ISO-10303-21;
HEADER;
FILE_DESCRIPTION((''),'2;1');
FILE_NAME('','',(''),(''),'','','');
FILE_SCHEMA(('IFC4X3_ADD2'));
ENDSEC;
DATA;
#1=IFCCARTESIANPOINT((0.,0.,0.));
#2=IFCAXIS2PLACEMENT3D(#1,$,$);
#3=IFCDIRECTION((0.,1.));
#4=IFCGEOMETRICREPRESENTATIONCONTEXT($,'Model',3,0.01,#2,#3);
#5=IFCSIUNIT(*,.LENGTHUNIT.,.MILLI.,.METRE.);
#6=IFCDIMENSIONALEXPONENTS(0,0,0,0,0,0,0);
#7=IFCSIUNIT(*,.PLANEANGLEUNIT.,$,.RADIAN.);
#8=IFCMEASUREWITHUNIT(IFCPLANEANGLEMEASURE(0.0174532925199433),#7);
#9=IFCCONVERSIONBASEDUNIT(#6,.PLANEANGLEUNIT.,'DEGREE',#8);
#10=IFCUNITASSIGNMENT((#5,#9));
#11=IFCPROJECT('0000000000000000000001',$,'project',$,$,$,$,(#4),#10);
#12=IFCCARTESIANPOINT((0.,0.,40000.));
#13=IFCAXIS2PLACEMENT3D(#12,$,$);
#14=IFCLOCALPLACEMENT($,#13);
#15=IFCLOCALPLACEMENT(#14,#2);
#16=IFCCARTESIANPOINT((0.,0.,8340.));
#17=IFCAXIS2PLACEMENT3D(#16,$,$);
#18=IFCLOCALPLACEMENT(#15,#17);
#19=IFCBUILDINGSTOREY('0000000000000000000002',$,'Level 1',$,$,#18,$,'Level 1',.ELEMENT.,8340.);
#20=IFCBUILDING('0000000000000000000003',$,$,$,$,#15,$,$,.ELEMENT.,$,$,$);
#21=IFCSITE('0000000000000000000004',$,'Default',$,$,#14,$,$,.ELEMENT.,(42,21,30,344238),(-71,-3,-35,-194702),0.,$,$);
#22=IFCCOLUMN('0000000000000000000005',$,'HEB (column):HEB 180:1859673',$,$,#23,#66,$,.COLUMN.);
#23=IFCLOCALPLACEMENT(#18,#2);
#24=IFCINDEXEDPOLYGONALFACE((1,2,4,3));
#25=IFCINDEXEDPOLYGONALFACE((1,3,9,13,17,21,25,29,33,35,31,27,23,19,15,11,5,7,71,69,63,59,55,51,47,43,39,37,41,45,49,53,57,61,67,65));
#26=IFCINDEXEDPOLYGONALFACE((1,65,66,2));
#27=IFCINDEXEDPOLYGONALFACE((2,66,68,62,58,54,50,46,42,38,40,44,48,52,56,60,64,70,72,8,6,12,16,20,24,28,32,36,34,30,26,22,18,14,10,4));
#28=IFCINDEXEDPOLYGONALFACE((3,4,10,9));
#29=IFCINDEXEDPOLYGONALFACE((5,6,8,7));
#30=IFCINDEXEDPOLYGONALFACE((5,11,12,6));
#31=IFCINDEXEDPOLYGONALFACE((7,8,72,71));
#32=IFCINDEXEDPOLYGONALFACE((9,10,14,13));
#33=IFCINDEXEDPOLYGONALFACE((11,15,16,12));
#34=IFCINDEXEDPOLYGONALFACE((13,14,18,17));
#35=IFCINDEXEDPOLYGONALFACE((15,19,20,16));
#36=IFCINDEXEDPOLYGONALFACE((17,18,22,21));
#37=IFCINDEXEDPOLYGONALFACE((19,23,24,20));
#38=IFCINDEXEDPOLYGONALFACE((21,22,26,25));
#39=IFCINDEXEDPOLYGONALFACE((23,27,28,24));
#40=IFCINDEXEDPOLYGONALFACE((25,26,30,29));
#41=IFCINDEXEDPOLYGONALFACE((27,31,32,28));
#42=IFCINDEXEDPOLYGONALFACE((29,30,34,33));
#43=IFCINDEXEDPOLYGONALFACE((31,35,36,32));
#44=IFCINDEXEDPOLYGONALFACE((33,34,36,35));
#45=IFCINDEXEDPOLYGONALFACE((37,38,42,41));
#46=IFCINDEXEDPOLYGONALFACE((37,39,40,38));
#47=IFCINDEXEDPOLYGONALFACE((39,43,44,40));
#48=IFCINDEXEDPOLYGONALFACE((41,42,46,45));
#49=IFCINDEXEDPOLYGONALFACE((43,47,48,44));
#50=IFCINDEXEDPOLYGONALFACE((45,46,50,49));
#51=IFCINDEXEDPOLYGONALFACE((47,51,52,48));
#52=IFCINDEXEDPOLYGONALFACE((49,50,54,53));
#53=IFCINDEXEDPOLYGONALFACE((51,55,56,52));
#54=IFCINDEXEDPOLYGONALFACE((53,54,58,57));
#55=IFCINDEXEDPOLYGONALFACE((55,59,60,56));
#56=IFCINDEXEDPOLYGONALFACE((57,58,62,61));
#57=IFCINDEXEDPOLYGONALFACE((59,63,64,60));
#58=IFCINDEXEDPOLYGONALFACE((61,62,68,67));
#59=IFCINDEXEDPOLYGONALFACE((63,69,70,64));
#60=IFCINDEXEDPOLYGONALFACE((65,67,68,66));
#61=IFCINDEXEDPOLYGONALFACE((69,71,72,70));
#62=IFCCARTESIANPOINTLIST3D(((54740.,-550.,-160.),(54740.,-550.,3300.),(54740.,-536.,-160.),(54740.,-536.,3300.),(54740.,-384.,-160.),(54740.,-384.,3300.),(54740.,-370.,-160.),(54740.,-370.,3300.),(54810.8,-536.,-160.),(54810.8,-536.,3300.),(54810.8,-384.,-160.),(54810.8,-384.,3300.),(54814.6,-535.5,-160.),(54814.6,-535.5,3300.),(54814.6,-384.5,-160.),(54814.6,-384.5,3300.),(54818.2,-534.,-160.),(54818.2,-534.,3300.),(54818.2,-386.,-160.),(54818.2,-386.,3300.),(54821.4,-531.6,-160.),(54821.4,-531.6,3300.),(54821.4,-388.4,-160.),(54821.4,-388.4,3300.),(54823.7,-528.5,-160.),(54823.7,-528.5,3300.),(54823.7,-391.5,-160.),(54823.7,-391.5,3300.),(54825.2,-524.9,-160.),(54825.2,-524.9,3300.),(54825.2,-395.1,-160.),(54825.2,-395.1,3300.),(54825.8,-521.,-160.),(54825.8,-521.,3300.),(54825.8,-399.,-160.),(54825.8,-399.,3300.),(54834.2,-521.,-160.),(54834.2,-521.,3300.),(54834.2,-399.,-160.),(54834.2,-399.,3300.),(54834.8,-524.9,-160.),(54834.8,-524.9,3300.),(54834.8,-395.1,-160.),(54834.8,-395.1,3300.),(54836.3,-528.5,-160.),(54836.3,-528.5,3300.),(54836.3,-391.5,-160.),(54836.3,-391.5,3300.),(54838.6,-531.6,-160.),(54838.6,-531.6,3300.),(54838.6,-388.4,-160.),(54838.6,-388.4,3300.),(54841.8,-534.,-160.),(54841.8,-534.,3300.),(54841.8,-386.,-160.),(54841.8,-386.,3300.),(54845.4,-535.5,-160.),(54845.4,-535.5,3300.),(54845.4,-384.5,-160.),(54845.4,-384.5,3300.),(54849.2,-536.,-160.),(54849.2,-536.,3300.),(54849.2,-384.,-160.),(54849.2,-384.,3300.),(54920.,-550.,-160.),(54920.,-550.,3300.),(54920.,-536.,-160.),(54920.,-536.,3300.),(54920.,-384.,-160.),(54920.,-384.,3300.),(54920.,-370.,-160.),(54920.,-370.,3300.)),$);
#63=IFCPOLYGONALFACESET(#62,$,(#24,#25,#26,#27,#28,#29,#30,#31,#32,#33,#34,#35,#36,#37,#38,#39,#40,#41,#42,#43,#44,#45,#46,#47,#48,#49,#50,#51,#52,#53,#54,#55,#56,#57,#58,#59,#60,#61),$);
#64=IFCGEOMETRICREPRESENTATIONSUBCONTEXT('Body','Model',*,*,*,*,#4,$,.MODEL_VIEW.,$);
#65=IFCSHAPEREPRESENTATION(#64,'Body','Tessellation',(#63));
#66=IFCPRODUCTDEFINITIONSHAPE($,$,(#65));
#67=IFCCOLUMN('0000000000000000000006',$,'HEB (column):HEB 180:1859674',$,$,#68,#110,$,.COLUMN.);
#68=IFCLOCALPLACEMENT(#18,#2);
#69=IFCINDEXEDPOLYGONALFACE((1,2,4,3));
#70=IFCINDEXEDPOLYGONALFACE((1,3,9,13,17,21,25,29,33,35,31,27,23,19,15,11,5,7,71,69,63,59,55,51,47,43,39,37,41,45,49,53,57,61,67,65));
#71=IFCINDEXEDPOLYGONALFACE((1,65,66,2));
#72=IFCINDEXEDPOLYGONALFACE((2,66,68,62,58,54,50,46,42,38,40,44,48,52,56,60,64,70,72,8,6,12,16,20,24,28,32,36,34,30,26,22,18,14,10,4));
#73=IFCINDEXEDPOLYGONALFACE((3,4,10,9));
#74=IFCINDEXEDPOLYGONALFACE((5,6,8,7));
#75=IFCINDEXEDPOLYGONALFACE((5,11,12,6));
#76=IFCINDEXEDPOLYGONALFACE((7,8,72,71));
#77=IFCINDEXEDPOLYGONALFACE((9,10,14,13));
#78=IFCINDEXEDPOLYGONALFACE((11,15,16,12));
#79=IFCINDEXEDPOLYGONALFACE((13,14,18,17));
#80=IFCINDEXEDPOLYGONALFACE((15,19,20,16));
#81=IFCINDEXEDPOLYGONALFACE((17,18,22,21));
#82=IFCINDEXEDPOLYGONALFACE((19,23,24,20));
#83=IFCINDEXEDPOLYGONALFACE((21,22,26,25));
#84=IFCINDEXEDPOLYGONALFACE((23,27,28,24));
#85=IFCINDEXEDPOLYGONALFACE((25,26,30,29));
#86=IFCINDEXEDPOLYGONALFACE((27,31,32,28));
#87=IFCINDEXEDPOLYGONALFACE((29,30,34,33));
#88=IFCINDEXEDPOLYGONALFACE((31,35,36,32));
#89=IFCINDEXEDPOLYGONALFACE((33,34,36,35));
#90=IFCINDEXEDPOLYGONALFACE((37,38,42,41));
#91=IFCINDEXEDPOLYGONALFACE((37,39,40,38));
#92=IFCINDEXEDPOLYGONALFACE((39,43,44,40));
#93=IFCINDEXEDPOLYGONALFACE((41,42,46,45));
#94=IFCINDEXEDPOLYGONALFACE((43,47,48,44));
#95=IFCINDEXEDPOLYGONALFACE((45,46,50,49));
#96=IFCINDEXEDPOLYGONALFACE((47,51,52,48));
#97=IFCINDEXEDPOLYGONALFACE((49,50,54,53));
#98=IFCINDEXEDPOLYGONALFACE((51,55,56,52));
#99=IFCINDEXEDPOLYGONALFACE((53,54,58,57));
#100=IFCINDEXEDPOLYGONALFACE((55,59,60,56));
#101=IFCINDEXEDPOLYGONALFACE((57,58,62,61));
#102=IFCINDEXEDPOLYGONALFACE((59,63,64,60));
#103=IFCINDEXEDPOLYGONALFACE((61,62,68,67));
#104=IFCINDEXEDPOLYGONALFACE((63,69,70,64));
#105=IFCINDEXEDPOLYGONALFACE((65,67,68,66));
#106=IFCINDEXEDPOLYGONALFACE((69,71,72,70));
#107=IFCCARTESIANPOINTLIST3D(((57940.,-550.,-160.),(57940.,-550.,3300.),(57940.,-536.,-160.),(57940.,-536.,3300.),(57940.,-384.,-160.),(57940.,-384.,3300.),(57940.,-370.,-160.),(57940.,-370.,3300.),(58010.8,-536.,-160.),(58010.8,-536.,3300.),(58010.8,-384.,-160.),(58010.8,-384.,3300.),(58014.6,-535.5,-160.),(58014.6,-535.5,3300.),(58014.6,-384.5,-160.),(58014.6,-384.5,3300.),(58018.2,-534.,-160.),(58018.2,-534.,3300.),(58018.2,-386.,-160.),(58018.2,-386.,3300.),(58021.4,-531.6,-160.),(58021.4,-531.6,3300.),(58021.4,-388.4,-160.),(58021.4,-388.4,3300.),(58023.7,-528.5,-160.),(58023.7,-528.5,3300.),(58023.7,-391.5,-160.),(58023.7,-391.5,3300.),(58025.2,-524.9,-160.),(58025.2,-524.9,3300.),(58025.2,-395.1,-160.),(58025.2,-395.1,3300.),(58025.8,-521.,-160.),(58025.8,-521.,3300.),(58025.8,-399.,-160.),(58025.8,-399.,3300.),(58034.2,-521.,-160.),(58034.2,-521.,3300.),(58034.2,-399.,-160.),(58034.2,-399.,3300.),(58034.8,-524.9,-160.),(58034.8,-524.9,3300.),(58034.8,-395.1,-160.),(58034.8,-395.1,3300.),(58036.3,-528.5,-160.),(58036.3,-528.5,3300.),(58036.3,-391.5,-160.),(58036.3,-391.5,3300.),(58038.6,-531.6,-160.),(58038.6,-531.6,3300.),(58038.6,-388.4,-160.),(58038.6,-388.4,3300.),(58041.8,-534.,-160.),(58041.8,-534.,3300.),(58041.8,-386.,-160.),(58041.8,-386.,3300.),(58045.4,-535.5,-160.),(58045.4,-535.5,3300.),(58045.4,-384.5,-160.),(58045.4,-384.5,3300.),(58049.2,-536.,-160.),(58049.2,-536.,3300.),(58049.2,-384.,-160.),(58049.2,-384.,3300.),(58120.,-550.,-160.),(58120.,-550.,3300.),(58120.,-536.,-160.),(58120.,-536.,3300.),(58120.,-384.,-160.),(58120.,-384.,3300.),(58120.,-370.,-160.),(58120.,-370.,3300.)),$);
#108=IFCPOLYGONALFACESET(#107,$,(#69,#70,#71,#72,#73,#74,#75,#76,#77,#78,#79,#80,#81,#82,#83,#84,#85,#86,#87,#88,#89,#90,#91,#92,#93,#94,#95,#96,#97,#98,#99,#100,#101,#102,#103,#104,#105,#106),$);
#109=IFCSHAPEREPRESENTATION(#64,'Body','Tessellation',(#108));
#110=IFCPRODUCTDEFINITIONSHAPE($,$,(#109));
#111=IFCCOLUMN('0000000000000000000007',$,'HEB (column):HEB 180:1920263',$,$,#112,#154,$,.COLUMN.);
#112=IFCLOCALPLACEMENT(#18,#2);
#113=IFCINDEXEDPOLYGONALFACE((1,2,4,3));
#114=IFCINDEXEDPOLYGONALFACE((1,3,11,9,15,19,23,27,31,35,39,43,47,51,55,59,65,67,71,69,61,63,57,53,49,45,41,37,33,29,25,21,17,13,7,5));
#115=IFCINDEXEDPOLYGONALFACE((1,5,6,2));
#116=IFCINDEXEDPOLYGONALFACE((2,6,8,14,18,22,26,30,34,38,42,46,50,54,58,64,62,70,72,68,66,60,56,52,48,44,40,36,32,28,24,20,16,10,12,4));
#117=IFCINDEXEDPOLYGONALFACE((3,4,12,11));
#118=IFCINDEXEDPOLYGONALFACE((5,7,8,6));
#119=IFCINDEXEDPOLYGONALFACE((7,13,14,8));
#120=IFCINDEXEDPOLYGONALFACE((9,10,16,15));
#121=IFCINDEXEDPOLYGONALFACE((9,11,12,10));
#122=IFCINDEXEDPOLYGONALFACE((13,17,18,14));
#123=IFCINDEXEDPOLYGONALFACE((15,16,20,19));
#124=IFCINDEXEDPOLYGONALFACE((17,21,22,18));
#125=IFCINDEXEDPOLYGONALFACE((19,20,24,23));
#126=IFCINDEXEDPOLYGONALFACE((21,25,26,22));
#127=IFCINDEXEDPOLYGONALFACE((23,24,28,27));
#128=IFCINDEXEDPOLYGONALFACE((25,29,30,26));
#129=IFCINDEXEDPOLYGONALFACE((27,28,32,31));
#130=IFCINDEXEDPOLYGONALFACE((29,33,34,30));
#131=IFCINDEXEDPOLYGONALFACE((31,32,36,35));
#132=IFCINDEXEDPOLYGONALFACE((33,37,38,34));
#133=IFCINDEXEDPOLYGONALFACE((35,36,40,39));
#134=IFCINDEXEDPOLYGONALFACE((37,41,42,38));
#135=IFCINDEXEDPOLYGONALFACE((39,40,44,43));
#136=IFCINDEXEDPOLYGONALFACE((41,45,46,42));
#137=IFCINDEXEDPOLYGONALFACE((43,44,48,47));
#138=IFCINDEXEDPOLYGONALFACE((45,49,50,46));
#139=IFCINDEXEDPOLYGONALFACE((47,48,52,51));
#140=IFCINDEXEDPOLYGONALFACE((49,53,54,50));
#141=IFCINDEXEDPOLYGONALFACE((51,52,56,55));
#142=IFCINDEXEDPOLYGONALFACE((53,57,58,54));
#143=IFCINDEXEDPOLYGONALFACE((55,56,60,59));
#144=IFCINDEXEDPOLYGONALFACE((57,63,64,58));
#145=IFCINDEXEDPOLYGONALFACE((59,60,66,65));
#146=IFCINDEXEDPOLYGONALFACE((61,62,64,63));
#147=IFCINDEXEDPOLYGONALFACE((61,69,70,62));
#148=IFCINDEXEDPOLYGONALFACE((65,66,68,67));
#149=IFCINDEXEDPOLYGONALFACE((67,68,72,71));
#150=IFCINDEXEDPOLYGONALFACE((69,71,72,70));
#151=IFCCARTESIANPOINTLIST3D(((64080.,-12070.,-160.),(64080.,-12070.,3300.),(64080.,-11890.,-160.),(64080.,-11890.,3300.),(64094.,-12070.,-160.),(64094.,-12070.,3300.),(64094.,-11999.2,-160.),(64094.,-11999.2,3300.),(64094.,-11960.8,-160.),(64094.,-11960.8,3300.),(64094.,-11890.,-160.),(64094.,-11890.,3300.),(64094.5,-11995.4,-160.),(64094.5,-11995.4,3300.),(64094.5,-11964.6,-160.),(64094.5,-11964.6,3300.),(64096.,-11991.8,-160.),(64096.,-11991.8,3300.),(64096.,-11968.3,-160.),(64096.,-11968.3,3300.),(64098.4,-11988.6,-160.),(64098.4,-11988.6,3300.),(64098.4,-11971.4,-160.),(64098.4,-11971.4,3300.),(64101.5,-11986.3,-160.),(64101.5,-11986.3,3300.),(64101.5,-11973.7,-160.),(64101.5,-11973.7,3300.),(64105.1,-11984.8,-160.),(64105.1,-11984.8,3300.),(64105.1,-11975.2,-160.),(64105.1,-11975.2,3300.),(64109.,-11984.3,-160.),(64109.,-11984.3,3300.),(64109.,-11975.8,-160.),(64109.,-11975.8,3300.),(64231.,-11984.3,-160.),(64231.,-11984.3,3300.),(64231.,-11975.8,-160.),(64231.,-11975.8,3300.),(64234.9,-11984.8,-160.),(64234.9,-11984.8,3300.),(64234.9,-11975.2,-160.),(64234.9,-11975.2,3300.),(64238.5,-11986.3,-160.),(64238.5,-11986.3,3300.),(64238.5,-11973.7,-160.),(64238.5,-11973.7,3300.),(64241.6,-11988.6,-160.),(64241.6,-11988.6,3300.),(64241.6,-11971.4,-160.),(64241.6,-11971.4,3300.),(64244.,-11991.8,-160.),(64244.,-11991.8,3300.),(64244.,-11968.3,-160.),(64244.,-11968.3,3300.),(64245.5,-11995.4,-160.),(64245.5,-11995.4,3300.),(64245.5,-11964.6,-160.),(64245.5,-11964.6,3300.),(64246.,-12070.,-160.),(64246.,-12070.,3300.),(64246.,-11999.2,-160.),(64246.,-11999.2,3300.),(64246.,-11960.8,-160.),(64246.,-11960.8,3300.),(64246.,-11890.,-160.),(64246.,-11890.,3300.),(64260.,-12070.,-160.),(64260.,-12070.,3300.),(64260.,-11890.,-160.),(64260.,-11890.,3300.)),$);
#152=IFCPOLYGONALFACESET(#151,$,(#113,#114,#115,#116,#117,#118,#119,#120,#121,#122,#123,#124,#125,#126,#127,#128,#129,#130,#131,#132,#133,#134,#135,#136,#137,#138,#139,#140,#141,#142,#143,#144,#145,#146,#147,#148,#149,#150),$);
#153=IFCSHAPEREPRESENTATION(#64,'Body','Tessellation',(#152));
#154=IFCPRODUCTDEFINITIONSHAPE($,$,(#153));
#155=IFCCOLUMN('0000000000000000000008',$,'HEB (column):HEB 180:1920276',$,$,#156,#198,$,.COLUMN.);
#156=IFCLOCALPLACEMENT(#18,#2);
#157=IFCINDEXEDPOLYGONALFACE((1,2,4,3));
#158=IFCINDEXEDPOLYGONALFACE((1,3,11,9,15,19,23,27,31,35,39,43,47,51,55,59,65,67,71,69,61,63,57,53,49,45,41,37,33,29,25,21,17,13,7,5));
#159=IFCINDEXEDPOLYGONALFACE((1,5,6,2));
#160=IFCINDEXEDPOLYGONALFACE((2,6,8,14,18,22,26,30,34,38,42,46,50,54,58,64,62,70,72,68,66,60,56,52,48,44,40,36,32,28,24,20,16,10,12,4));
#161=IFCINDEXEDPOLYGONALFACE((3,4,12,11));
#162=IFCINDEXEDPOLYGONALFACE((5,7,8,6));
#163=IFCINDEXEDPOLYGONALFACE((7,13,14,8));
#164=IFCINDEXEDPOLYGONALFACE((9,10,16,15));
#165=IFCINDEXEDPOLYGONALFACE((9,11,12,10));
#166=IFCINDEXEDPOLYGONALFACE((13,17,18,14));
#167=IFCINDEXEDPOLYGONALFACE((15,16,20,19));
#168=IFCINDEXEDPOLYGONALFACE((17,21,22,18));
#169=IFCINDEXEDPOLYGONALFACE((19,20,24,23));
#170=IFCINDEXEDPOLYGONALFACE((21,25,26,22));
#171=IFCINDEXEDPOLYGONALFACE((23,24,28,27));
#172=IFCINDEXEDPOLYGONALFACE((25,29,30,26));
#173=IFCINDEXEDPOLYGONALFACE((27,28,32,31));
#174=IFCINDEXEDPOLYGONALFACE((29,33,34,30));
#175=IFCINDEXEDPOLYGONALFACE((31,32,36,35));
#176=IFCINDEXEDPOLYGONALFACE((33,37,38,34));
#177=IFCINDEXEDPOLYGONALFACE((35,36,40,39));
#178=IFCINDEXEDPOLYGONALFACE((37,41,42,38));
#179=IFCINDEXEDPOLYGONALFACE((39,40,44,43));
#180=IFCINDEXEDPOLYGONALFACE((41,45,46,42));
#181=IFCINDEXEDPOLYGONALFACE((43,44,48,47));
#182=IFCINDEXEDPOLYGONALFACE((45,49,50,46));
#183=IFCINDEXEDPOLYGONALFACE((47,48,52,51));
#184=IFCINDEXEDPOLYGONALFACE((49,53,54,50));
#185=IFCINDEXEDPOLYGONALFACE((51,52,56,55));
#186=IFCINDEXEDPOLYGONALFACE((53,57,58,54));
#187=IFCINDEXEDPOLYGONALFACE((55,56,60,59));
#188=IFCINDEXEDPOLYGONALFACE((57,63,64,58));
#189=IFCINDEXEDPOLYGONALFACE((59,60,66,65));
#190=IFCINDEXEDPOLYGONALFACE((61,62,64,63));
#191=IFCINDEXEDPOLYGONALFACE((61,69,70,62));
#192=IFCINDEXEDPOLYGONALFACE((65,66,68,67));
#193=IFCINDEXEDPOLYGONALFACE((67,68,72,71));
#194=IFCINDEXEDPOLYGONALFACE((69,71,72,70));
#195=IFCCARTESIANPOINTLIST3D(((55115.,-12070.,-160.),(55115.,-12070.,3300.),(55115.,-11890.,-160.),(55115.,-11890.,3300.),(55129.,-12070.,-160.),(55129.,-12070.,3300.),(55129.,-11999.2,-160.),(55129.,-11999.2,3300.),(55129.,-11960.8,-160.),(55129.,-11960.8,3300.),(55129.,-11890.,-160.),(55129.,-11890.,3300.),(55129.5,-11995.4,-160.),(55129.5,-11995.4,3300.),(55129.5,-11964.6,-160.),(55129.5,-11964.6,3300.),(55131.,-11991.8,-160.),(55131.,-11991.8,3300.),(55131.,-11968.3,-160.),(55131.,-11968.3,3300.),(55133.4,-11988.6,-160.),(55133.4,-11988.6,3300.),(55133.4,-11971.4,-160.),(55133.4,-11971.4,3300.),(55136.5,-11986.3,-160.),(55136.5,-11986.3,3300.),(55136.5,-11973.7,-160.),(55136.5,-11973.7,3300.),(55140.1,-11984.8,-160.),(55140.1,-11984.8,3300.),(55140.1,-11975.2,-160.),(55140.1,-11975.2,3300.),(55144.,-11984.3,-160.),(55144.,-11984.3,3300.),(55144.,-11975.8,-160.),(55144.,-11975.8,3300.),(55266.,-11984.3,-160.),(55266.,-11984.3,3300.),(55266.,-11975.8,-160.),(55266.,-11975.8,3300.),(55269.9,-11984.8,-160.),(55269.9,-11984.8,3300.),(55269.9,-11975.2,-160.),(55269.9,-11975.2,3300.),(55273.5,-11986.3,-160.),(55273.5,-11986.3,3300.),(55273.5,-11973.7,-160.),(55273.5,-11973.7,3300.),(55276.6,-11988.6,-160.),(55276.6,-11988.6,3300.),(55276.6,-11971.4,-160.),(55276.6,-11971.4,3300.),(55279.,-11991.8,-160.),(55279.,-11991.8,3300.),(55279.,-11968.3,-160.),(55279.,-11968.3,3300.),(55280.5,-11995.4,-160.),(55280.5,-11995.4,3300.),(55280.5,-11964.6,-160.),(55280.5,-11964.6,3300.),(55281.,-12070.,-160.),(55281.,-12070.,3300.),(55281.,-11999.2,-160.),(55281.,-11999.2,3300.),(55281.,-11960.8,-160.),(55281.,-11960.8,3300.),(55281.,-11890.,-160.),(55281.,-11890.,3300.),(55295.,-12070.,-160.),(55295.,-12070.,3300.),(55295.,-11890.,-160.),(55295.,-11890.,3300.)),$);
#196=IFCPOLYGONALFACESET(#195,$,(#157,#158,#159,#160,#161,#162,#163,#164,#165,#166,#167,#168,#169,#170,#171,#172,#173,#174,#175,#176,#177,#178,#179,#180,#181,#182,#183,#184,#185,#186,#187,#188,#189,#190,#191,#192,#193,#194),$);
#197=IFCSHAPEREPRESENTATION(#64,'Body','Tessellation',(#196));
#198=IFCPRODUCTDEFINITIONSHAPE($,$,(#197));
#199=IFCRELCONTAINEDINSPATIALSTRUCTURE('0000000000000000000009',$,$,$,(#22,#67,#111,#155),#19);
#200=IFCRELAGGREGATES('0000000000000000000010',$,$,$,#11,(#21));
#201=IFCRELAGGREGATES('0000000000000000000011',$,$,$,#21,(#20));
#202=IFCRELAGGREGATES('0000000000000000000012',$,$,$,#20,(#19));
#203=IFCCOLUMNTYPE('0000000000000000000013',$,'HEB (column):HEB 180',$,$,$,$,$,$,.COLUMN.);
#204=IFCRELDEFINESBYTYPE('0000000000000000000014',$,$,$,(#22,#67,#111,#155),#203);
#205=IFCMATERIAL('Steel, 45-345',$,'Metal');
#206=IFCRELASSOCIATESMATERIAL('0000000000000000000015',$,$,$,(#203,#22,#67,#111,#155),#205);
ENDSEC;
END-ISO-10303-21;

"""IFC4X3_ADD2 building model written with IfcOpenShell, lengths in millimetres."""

from ifc_helpers import new_model, entity, si_unit, converted_unit, direction, frame, origin, origin_2d_with_axis, place, context, subcontext, project, spatial, i_section, extrude, source, transform, mapped, material, material_profile, profile_set, profile_usage, type_object, type_shapes, element, save


model = new_model("IFC4X3_ADD2")

# Units and contexts
model_context = context("Model", 3, precision=0.01, world=origin(), true_north=direction((0.0, 1.0)))
body_context = subcontext(model_context, "Body", "Model", "MODEL_VIEW")
ifc_project = project(units=[si_unit("LENGTHUNIT", "METRE", prefix="MILLI"), converted_unit("PLANEANGLEUNIT", "DEGREE", entity("IfcPlaneAngleMeasure", 0.0174532925199433), si_unit("PLANEANGLEUNIT", "RADIAN"), dimensions=[0, 0, 0, 0, 0, 0, 0])], contexts=[model_context])

# Site, building, storey
site_placement = place(None, frame((0.0, 0.0, 40000.0)))
site = spatial("IfcSite", under=ifc_project, at=site_placement, Name="Default", CompositionType="ELEMENT", RefLatitude=(42, 21, 30, 344238), RefLongitude=(-71, -3, -35, -194702), RefElevation=0.0)
building_placement = place(site_placement, origin())
building = spatial("IfcBuilding", under=site, at=building_placement, CompositionType="ELEMENT")
storey_placement = place(building_placement, frame((0.0, 0.0, 8340.0)))
storey = spatial("IfcBuildingStorey", under=building, at=storey_placement, Name="Level 1", LongName="Level 1", CompositionType="ELEMENT", Elevation=8340.0)

# Columns
ifc_material = material(Name="Steel, 45-345", Category="Metal")
ifc_material_profile_1 = material_profile(ifc_material, i_section(OverallWidth=180.0, OverallDepth=180.0, WebThickness=8.5, FlangeThickness=14.0, FilletRadius=15.0, at=origin_2d_with_axis()), Name="HEB 180")
ifc_profile_set_1 = profile_set([ifc_material_profile_1], Name="HEB 180")
ifc_profile_usage_1 = profile_usage(ifc_profile_set_1)
column_type_1 = type_object("IfcColumnType", Name="HEB (column):HEB 180", PredefinedType="COLUMN", material=ifc_profile_set_1)
shared_shape_1 = source(origin(), body_context, "Body", "SweptSolid", [
    extrude(i_section(OverallWidth=180.0, OverallDepth=180.0, WebThickness=8.5, FlangeThickness=14.0, FilletRadius=15.0, at=origin_2d_with_axis()), frame((0.0, 0.0, 8180.0), z_axis=(0.0, 0.0, 1.0), x_axis=(-1.0, 0.0, 0.0)), (0.0, 0.0, 1.0), 3460.0),
])
type_shapes(column_type_1, [shared_shape_1])
for number, where, name in (
    (1, (54830.0, -460.0, -8340.0), "HEB (column):HEB 180:1859673"),
    (2, (58030.0, -460.0, -8340.0), "HEB (column):HEB 180:1859674"),
):
    element("IfcColumn", number, at=place(storey_placement, frame(where)), inside=storey, type_object=column_type_1, material=ifc_profile_usage_1, Name=name, PredefinedType="COLUMN", context=body_context, shape_type="MappedRepresentation", body=[
        mapped(shared_shape_1, transform((0.0, 0.0, 0.0), scale=1.0)),
    ])
for number, where, z_axis, x_axis, name in (
    (3, (64170.0, -11980.0, -8340.0), (0.0, 0.0, 1.0), (0.0, -1.0, 0.0), "HEB (column):HEB 180:1920263"),
    (4, (55205.0, -11980.0, -8340.0), (0.0, 0.0, 1.0), (0.0, -1.0, 0.0), "HEB (column):HEB 180:1920276"),
):
    element("IfcColumn", number, at=place(storey_placement, frame(where, z_axis=z_axis, x_axis=x_axis)), inside=storey, type_object=column_type_1, material=ifc_profile_usage_1, Name=name, PredefinedType="COLUMN", context=body_context, shape_type="MappedRepresentation", body=[
        mapped(shared_shape_1, transform((0.0, 0.0, 0.0), scale=1.0)),
    ])

save(model, "model.ifc")
